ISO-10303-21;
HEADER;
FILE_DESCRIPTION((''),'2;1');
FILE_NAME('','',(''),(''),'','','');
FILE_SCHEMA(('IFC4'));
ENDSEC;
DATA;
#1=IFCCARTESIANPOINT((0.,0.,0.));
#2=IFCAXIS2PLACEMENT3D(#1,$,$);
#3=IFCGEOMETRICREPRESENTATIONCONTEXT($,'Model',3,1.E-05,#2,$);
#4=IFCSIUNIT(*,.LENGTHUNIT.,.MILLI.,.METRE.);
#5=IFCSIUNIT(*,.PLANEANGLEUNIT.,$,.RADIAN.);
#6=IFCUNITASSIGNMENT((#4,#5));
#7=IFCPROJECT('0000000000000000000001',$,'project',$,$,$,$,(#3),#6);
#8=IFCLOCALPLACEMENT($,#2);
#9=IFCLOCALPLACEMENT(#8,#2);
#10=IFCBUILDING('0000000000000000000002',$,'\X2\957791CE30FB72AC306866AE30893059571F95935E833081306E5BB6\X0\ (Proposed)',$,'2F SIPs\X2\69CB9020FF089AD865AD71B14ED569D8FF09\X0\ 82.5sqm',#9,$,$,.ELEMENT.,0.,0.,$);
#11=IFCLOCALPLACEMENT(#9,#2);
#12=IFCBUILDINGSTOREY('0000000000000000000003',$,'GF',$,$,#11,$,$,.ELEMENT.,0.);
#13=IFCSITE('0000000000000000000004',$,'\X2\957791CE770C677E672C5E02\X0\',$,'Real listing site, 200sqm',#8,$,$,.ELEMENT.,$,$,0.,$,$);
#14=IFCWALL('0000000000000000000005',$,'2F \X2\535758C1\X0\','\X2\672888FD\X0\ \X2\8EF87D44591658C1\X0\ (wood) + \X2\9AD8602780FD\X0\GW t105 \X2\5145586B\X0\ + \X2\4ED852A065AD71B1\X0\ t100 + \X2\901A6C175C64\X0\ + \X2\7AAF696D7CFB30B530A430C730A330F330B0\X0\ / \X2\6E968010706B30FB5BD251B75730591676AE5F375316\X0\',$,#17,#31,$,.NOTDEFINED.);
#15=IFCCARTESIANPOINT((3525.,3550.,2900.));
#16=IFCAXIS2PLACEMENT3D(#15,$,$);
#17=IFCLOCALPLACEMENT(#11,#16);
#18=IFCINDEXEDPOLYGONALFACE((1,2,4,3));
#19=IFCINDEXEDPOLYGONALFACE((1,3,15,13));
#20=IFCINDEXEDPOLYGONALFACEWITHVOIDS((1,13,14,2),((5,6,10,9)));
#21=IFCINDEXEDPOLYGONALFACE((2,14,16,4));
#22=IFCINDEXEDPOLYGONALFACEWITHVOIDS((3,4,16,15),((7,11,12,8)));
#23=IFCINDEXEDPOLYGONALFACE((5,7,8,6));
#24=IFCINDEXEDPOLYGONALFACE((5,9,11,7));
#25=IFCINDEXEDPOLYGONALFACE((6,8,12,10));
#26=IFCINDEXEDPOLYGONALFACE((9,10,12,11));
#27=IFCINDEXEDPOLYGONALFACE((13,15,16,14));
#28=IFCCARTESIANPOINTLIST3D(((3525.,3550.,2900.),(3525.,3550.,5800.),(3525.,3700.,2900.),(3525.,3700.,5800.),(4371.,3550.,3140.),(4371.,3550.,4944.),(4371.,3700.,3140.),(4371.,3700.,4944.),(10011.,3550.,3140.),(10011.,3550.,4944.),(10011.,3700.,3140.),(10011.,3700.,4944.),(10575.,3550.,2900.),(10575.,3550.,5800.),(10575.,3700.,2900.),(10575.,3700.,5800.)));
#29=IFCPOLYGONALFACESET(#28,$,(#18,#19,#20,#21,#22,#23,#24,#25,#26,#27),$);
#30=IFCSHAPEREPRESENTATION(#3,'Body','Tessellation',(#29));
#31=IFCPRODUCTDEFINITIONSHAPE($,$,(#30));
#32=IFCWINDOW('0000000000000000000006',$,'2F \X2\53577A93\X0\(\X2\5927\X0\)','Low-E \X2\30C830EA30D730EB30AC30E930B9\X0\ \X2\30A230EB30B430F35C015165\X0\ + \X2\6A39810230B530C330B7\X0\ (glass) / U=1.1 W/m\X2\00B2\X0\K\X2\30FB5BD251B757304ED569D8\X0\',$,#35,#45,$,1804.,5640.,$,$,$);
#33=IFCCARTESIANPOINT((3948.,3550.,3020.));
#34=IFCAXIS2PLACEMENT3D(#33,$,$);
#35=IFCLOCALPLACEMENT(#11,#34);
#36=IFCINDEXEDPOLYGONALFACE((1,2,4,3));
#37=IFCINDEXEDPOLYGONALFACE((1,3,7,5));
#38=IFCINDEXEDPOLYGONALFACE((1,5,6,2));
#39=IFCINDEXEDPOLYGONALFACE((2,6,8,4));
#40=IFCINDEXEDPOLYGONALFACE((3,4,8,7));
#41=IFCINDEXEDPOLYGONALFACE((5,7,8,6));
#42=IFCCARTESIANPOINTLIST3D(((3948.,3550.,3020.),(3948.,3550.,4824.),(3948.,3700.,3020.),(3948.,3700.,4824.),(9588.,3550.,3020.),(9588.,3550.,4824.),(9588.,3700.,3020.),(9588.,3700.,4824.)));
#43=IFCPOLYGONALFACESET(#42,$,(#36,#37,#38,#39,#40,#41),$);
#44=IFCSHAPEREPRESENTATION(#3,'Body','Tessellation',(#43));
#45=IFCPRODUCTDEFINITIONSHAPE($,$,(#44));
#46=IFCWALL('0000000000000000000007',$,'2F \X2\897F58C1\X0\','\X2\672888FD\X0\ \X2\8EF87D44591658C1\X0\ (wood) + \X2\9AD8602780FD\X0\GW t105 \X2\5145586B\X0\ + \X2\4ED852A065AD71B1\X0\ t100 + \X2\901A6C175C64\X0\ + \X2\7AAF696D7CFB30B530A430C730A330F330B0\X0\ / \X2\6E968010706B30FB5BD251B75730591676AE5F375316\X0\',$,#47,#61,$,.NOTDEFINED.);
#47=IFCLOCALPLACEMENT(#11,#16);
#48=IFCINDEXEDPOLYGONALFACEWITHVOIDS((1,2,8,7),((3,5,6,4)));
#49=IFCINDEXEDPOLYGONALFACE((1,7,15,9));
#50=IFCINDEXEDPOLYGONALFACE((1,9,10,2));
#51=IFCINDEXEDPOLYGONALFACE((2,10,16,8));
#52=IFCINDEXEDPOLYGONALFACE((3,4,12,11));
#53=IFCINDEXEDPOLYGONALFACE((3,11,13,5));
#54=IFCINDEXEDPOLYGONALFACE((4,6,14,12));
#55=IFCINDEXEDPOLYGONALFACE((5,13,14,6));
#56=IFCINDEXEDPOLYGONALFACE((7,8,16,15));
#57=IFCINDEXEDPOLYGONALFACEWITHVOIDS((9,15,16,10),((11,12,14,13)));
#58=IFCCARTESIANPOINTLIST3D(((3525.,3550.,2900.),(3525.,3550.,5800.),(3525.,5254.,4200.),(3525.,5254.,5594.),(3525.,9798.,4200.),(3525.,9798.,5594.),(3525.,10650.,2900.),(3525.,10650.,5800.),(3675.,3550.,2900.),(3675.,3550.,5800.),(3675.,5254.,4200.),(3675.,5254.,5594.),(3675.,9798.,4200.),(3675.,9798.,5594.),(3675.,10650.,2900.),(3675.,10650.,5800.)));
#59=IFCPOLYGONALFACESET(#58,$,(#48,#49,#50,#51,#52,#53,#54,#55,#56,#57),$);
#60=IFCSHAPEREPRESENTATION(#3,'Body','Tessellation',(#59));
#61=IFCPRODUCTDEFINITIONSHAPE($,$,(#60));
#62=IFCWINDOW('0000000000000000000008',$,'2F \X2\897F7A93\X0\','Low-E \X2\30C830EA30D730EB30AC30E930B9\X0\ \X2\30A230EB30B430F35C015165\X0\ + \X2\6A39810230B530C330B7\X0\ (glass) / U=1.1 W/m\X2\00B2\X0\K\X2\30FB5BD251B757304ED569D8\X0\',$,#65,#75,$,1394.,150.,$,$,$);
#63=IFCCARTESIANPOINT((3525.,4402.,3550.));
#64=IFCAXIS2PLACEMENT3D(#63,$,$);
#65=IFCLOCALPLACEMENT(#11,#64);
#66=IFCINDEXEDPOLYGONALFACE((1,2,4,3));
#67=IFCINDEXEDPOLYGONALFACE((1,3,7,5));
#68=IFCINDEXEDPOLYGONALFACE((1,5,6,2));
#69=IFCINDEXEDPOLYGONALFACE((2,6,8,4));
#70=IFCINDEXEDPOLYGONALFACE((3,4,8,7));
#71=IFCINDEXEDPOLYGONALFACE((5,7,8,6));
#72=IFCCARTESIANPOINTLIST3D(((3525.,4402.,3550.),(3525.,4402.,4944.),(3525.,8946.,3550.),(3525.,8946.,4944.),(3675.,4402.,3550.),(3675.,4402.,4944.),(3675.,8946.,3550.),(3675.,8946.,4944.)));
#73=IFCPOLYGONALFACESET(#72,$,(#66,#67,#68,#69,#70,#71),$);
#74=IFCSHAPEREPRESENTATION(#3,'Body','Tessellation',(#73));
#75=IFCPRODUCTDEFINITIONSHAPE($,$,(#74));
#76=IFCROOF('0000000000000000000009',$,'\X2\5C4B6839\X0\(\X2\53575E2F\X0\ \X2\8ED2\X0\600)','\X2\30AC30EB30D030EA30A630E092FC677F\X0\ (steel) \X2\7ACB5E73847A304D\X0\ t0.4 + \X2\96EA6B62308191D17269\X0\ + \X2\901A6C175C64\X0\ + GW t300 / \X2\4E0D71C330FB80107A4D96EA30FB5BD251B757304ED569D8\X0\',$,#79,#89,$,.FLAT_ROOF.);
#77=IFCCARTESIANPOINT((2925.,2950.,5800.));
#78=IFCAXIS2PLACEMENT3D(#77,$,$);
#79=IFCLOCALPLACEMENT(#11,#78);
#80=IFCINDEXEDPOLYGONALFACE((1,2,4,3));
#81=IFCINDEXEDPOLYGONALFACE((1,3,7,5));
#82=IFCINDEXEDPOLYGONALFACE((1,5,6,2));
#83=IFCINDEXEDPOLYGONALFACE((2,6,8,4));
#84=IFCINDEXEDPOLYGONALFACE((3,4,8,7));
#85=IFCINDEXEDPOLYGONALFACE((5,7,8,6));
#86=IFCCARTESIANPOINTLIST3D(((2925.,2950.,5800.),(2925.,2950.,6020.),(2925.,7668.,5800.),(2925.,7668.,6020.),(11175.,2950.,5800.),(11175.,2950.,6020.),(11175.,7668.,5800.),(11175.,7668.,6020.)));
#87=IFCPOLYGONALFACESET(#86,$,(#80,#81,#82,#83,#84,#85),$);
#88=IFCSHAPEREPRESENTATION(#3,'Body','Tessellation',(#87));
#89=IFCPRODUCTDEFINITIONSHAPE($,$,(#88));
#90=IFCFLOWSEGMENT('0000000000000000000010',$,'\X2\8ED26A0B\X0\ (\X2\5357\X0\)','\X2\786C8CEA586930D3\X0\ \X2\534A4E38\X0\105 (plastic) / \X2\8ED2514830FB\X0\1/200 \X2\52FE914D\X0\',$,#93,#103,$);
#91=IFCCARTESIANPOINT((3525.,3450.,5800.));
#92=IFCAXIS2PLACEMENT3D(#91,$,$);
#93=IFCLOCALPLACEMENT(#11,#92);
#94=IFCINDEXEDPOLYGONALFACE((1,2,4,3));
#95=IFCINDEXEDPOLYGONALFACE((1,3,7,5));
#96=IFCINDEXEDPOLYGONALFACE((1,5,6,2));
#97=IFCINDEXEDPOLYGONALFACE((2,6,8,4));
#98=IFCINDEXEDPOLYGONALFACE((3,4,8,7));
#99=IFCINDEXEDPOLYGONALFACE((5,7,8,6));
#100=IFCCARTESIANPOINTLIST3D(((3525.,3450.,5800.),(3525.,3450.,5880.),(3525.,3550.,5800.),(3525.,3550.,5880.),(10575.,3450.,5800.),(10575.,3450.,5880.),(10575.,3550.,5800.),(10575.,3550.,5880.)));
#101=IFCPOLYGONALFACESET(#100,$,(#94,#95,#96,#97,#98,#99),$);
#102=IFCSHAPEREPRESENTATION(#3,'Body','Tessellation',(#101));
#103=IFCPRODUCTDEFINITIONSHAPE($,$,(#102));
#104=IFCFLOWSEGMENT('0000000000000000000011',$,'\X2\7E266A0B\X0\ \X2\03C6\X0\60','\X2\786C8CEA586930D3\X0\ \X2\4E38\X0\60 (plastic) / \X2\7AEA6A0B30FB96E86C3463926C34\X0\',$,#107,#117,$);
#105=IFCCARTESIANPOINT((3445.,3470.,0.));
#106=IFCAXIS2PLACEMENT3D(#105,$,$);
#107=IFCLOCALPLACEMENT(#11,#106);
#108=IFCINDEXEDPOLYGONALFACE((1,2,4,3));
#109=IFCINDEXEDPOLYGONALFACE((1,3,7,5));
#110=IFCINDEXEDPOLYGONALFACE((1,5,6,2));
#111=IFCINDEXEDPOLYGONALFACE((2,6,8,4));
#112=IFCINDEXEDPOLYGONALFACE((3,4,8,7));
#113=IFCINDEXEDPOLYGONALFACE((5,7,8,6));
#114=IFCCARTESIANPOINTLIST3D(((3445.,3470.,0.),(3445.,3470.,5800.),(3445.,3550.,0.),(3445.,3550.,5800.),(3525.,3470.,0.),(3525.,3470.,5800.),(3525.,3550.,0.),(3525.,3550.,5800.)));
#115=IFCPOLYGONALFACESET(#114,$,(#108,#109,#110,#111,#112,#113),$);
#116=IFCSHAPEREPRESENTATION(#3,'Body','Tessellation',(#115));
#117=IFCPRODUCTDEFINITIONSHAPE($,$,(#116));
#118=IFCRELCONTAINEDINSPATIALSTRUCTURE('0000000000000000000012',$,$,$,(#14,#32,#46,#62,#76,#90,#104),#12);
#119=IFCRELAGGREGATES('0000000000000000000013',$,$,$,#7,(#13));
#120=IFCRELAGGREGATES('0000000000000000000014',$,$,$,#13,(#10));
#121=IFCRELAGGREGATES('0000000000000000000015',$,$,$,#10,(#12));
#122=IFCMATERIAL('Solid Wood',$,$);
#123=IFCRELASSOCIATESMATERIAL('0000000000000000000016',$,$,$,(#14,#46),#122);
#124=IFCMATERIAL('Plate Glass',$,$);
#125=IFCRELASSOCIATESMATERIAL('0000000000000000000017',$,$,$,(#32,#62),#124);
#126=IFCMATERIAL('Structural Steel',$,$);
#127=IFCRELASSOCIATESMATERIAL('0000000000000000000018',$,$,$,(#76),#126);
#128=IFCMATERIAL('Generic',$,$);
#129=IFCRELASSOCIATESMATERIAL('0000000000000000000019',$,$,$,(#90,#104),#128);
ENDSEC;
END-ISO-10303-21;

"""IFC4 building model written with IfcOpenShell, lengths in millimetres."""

from ifc_helpers import new_model, si_unit, frame, frame_2d, origin, place, context, project, spatial, rectangle, extrude, material, element, fill, save


model = new_model("IFC4")

# Units and contexts
model_context = context("Model", 3, precision=1e-05, world=origin())
ifc_project = project(units=[si_unit("LENGTHUNIT", "METRE", prefix="MILLI"), si_unit("PLANEANGLEUNIT", "RADIAN")], contexts=[model_context])

# Site, building, storey
site_placement = place(None, origin())
site = spatial("IfcSite", under=ifc_project, at=site_placement, Name="長野県松本市", ObjectType="Real listing site, 200sqm", CompositionType="ELEMENT", RefElevation=0.0)
building_placement = place(site_placement, origin())
building = spatial("IfcBuilding", under=site, at=building_placement, Name="長野・犬と暮らす土間広めの家 (Proposed)", ObjectType="2F SIPs構造（高断熱仕様） 82.5sqm", CompositionType="ELEMENT", ElevationOfRefHeight=0.0, ElevationOfTerrain=0.0)
storey_placement = place(building_placement, origin())
storey = spatial("IfcBuildingStorey", under=building, at=storey_placement, Name="GF", CompositionType="ELEMENT", Elevation=0.0)

# Shared definitions
ifc_material_1 = material(Name="Solid Wood")

# Shared definitions
ifc_material_2 = material(Name="Plate Glass")

# Walls, openings, windows
wall_1_placement = place(storey_placement, frame((3525.0, 3550.0, 2900.0)))
wall_1 = element("IfcWall", 1, at=wall_1_placement, inside=storey, material=ifc_material_1, Name="2F 南壁", Description="木製 軸組外壁 (wood) + 高性能GW t105 充填 + 付加断熱 t100 + 通気層 + 窯業系サイディング / 準耐火・寒冷地外皮強化", PredefinedType="NOTDEFINED", context=model_context, shape_type="SweptSolid", body=[
    extrude(rectangle(XDim=7050.0, YDim=150.0, at=frame_2d((3525.0, 75.0))), frame((3525.0, 3550.0, 2900.0)), (0.0, 0.0, 1.0), 2900.0),
])
opening_1_placement = place(storey_placement, frame((3948.0, 3550.0, 3020.0)))
opening_1 = element("IfcOpeningElement", 2, at=opening_1_placement, cuts=wall_1, PredefinedType="NOTDEFINED", context=model_context, shape_type="SweptSolid", body=[
    extrude(rectangle(XDim=5640.0, YDim=150.0, at=frame_2d((2820.0, 75.0))), frame((3948.0, 3550.0, 3020.0)), (0.0, 0.0, 1.0), 1804.0),
])
window_1_placement = place(storey_placement, frame((3948.0, 3550.0, 3020.0)))
window_1 = element("IfcWindow", 3, at=window_1_placement, inside=storey, material=ifc_material_2, Name="2F 南窓(大)", Description="Low-E トリプルガラス アルゴン封入 + 樹脂サッシ (glass) / U=1.1 W/m²K・寒冷地仕様", OverallHeight=1804.0, OverallWidth=5640.0, context=model_context, shape_type="SweptSolid", body=[
    extrude(rectangle(XDim=5640.0, YDim=150.0, at=frame_2d((2820.0, 75.0))), frame((3948.0, 3550.0, 3020.0)), (0.0, 0.0, 1.0), 1804.0),
])
fill(opening_1, window_1)
wall_2_placement = place(storey_placement, frame((3525.0, 3550.0, 2900.0)))
wall_2 = element("IfcWall", 4, at=wall_2_placement, inside=storey, material=ifc_material_1, Name="2F 西壁", Description="木製 軸組外壁 (wood) + 高性能GW t105 充填 + 付加断熱 t100 + 通気層 + 窯業系サイディング / 準耐火・寒冷地外皮強化", PredefinedType="NOTDEFINED", context=model_context, shape_type="SweptSolid", body=[
    extrude(rectangle(XDim=150.0, YDim=7100.0, at=frame_2d((75.0, 3550.0))), frame((3525.0, 3550.0, 2900.0)), (0.0, 0.0, 1.0), 2900.0),
])
opening_2_placement = place(storey_placement, frame((3525.0, 4402.0, 3550.0)))
opening_2 = element("IfcOpeningElement", 5, at=opening_2_placement, cuts=wall_2, PredefinedType="NOTDEFINED", context=model_context, shape_type="SweptSolid", body=[
    extrude(rectangle(XDim=150.0, YDim=4544.0, at=frame_2d((75.0, 2272.0))), frame((3525.0, 4402.0, 3550.0)), (0.0, 0.0, 1.0), 1394.0),
])
window_2_placement = place(storey_placement, frame((3525.0, 4402.0, 3550.0)))
window_2 = element("IfcWindow", 6, at=window_2_placement, inside=storey, material=ifc_material_2, Name="2F 西窓", Description="Low-E トリプルガラス アルゴン封入 + 樹脂サッシ (glass) / U=1.1 W/m²K・寒冷地仕様", OverallHeight=1394.0, OverallWidth=150.0, context=model_context, shape_type="SweptSolid", body=[
    extrude(rectangle(XDim=150.0, YDim=4544.0, at=frame_2d((75.0, 2272.0))), frame((3525.0, 4402.0, 3550.0)), (0.0, 0.0, 1.0), 1394.0),
])
fill(opening_2, window_2)

# Roof
ifc_material_3 = material(Name="Structural Steel")
for number, where, name in (
    (7, (2925.0, 2950.0, 5800.0), "屋根(南帯 軒600)"),
):
    element("IfcRoof", number, at=place(storey_placement, frame(where)), inside=storey, material=ifc_material_3, Name=name, Description="ガルバリウム鋼板 (steel) 立平葺き t0.4 + 雪止め金物 + 通気層 + GW t300 / 不燃・耐積雪・寒冷地仕様", PredefinedType="FLAT_ROOF", context=model_context, shape_type="SweptSolid", body=[
        extrude(rectangle(XDim=8250.0, YDim=4718.0, at=frame_2d((4125.0, 2359.0))), frame((2925.0, 2950.0, 5800.0)), (0.0, 0.0, 1.0), 220.0),
    ])

# Flow segments
ifc_material_4 = material(Name="Generic")
flow_segment_1_placement = place(storey_placement, frame((3525.0, 3450.0, 5800.0)))
element("IfcFlowSegment", 8, at=flow_segment_1_placement, inside=storey, material=ifc_material_4, Name="軒樋 (南)", Description="硬質塩ビ 半丸105 (plastic) / 軒先・1/200 勾配", context=model_context, shape_type="SweptSolid", body=[
    extrude(rectangle(XDim=7050.0, YDim=100.0, at=frame_2d((3525.0, 50.0))), frame((3525.0, 3450.0, 5800.0)), (0.0, 0.0, 1.0), 80.0),
])
flow_segment_2_placement = place(storey_placement, frame((3445.0, 3470.0, 0.0)))
element("IfcFlowSegment", 9, at=flow_segment_2_placement, inside=storey, material=ifc_material_4, Name="縦樋 φ60", Description="硬質塩ビ 丸60 (plastic) / 竪樋・雨水排水", context=model_context, shape_type="SweptSolid", body=[
    extrude(rectangle(XDim=80.0, YDim=80.0, at=frame_2d((40.0, 40.0))), frame((3445.0, 3470.0, 0.0)), (0.0, 0.0, 1.0), 5800.0),
])

save(model, "model.ifc")
